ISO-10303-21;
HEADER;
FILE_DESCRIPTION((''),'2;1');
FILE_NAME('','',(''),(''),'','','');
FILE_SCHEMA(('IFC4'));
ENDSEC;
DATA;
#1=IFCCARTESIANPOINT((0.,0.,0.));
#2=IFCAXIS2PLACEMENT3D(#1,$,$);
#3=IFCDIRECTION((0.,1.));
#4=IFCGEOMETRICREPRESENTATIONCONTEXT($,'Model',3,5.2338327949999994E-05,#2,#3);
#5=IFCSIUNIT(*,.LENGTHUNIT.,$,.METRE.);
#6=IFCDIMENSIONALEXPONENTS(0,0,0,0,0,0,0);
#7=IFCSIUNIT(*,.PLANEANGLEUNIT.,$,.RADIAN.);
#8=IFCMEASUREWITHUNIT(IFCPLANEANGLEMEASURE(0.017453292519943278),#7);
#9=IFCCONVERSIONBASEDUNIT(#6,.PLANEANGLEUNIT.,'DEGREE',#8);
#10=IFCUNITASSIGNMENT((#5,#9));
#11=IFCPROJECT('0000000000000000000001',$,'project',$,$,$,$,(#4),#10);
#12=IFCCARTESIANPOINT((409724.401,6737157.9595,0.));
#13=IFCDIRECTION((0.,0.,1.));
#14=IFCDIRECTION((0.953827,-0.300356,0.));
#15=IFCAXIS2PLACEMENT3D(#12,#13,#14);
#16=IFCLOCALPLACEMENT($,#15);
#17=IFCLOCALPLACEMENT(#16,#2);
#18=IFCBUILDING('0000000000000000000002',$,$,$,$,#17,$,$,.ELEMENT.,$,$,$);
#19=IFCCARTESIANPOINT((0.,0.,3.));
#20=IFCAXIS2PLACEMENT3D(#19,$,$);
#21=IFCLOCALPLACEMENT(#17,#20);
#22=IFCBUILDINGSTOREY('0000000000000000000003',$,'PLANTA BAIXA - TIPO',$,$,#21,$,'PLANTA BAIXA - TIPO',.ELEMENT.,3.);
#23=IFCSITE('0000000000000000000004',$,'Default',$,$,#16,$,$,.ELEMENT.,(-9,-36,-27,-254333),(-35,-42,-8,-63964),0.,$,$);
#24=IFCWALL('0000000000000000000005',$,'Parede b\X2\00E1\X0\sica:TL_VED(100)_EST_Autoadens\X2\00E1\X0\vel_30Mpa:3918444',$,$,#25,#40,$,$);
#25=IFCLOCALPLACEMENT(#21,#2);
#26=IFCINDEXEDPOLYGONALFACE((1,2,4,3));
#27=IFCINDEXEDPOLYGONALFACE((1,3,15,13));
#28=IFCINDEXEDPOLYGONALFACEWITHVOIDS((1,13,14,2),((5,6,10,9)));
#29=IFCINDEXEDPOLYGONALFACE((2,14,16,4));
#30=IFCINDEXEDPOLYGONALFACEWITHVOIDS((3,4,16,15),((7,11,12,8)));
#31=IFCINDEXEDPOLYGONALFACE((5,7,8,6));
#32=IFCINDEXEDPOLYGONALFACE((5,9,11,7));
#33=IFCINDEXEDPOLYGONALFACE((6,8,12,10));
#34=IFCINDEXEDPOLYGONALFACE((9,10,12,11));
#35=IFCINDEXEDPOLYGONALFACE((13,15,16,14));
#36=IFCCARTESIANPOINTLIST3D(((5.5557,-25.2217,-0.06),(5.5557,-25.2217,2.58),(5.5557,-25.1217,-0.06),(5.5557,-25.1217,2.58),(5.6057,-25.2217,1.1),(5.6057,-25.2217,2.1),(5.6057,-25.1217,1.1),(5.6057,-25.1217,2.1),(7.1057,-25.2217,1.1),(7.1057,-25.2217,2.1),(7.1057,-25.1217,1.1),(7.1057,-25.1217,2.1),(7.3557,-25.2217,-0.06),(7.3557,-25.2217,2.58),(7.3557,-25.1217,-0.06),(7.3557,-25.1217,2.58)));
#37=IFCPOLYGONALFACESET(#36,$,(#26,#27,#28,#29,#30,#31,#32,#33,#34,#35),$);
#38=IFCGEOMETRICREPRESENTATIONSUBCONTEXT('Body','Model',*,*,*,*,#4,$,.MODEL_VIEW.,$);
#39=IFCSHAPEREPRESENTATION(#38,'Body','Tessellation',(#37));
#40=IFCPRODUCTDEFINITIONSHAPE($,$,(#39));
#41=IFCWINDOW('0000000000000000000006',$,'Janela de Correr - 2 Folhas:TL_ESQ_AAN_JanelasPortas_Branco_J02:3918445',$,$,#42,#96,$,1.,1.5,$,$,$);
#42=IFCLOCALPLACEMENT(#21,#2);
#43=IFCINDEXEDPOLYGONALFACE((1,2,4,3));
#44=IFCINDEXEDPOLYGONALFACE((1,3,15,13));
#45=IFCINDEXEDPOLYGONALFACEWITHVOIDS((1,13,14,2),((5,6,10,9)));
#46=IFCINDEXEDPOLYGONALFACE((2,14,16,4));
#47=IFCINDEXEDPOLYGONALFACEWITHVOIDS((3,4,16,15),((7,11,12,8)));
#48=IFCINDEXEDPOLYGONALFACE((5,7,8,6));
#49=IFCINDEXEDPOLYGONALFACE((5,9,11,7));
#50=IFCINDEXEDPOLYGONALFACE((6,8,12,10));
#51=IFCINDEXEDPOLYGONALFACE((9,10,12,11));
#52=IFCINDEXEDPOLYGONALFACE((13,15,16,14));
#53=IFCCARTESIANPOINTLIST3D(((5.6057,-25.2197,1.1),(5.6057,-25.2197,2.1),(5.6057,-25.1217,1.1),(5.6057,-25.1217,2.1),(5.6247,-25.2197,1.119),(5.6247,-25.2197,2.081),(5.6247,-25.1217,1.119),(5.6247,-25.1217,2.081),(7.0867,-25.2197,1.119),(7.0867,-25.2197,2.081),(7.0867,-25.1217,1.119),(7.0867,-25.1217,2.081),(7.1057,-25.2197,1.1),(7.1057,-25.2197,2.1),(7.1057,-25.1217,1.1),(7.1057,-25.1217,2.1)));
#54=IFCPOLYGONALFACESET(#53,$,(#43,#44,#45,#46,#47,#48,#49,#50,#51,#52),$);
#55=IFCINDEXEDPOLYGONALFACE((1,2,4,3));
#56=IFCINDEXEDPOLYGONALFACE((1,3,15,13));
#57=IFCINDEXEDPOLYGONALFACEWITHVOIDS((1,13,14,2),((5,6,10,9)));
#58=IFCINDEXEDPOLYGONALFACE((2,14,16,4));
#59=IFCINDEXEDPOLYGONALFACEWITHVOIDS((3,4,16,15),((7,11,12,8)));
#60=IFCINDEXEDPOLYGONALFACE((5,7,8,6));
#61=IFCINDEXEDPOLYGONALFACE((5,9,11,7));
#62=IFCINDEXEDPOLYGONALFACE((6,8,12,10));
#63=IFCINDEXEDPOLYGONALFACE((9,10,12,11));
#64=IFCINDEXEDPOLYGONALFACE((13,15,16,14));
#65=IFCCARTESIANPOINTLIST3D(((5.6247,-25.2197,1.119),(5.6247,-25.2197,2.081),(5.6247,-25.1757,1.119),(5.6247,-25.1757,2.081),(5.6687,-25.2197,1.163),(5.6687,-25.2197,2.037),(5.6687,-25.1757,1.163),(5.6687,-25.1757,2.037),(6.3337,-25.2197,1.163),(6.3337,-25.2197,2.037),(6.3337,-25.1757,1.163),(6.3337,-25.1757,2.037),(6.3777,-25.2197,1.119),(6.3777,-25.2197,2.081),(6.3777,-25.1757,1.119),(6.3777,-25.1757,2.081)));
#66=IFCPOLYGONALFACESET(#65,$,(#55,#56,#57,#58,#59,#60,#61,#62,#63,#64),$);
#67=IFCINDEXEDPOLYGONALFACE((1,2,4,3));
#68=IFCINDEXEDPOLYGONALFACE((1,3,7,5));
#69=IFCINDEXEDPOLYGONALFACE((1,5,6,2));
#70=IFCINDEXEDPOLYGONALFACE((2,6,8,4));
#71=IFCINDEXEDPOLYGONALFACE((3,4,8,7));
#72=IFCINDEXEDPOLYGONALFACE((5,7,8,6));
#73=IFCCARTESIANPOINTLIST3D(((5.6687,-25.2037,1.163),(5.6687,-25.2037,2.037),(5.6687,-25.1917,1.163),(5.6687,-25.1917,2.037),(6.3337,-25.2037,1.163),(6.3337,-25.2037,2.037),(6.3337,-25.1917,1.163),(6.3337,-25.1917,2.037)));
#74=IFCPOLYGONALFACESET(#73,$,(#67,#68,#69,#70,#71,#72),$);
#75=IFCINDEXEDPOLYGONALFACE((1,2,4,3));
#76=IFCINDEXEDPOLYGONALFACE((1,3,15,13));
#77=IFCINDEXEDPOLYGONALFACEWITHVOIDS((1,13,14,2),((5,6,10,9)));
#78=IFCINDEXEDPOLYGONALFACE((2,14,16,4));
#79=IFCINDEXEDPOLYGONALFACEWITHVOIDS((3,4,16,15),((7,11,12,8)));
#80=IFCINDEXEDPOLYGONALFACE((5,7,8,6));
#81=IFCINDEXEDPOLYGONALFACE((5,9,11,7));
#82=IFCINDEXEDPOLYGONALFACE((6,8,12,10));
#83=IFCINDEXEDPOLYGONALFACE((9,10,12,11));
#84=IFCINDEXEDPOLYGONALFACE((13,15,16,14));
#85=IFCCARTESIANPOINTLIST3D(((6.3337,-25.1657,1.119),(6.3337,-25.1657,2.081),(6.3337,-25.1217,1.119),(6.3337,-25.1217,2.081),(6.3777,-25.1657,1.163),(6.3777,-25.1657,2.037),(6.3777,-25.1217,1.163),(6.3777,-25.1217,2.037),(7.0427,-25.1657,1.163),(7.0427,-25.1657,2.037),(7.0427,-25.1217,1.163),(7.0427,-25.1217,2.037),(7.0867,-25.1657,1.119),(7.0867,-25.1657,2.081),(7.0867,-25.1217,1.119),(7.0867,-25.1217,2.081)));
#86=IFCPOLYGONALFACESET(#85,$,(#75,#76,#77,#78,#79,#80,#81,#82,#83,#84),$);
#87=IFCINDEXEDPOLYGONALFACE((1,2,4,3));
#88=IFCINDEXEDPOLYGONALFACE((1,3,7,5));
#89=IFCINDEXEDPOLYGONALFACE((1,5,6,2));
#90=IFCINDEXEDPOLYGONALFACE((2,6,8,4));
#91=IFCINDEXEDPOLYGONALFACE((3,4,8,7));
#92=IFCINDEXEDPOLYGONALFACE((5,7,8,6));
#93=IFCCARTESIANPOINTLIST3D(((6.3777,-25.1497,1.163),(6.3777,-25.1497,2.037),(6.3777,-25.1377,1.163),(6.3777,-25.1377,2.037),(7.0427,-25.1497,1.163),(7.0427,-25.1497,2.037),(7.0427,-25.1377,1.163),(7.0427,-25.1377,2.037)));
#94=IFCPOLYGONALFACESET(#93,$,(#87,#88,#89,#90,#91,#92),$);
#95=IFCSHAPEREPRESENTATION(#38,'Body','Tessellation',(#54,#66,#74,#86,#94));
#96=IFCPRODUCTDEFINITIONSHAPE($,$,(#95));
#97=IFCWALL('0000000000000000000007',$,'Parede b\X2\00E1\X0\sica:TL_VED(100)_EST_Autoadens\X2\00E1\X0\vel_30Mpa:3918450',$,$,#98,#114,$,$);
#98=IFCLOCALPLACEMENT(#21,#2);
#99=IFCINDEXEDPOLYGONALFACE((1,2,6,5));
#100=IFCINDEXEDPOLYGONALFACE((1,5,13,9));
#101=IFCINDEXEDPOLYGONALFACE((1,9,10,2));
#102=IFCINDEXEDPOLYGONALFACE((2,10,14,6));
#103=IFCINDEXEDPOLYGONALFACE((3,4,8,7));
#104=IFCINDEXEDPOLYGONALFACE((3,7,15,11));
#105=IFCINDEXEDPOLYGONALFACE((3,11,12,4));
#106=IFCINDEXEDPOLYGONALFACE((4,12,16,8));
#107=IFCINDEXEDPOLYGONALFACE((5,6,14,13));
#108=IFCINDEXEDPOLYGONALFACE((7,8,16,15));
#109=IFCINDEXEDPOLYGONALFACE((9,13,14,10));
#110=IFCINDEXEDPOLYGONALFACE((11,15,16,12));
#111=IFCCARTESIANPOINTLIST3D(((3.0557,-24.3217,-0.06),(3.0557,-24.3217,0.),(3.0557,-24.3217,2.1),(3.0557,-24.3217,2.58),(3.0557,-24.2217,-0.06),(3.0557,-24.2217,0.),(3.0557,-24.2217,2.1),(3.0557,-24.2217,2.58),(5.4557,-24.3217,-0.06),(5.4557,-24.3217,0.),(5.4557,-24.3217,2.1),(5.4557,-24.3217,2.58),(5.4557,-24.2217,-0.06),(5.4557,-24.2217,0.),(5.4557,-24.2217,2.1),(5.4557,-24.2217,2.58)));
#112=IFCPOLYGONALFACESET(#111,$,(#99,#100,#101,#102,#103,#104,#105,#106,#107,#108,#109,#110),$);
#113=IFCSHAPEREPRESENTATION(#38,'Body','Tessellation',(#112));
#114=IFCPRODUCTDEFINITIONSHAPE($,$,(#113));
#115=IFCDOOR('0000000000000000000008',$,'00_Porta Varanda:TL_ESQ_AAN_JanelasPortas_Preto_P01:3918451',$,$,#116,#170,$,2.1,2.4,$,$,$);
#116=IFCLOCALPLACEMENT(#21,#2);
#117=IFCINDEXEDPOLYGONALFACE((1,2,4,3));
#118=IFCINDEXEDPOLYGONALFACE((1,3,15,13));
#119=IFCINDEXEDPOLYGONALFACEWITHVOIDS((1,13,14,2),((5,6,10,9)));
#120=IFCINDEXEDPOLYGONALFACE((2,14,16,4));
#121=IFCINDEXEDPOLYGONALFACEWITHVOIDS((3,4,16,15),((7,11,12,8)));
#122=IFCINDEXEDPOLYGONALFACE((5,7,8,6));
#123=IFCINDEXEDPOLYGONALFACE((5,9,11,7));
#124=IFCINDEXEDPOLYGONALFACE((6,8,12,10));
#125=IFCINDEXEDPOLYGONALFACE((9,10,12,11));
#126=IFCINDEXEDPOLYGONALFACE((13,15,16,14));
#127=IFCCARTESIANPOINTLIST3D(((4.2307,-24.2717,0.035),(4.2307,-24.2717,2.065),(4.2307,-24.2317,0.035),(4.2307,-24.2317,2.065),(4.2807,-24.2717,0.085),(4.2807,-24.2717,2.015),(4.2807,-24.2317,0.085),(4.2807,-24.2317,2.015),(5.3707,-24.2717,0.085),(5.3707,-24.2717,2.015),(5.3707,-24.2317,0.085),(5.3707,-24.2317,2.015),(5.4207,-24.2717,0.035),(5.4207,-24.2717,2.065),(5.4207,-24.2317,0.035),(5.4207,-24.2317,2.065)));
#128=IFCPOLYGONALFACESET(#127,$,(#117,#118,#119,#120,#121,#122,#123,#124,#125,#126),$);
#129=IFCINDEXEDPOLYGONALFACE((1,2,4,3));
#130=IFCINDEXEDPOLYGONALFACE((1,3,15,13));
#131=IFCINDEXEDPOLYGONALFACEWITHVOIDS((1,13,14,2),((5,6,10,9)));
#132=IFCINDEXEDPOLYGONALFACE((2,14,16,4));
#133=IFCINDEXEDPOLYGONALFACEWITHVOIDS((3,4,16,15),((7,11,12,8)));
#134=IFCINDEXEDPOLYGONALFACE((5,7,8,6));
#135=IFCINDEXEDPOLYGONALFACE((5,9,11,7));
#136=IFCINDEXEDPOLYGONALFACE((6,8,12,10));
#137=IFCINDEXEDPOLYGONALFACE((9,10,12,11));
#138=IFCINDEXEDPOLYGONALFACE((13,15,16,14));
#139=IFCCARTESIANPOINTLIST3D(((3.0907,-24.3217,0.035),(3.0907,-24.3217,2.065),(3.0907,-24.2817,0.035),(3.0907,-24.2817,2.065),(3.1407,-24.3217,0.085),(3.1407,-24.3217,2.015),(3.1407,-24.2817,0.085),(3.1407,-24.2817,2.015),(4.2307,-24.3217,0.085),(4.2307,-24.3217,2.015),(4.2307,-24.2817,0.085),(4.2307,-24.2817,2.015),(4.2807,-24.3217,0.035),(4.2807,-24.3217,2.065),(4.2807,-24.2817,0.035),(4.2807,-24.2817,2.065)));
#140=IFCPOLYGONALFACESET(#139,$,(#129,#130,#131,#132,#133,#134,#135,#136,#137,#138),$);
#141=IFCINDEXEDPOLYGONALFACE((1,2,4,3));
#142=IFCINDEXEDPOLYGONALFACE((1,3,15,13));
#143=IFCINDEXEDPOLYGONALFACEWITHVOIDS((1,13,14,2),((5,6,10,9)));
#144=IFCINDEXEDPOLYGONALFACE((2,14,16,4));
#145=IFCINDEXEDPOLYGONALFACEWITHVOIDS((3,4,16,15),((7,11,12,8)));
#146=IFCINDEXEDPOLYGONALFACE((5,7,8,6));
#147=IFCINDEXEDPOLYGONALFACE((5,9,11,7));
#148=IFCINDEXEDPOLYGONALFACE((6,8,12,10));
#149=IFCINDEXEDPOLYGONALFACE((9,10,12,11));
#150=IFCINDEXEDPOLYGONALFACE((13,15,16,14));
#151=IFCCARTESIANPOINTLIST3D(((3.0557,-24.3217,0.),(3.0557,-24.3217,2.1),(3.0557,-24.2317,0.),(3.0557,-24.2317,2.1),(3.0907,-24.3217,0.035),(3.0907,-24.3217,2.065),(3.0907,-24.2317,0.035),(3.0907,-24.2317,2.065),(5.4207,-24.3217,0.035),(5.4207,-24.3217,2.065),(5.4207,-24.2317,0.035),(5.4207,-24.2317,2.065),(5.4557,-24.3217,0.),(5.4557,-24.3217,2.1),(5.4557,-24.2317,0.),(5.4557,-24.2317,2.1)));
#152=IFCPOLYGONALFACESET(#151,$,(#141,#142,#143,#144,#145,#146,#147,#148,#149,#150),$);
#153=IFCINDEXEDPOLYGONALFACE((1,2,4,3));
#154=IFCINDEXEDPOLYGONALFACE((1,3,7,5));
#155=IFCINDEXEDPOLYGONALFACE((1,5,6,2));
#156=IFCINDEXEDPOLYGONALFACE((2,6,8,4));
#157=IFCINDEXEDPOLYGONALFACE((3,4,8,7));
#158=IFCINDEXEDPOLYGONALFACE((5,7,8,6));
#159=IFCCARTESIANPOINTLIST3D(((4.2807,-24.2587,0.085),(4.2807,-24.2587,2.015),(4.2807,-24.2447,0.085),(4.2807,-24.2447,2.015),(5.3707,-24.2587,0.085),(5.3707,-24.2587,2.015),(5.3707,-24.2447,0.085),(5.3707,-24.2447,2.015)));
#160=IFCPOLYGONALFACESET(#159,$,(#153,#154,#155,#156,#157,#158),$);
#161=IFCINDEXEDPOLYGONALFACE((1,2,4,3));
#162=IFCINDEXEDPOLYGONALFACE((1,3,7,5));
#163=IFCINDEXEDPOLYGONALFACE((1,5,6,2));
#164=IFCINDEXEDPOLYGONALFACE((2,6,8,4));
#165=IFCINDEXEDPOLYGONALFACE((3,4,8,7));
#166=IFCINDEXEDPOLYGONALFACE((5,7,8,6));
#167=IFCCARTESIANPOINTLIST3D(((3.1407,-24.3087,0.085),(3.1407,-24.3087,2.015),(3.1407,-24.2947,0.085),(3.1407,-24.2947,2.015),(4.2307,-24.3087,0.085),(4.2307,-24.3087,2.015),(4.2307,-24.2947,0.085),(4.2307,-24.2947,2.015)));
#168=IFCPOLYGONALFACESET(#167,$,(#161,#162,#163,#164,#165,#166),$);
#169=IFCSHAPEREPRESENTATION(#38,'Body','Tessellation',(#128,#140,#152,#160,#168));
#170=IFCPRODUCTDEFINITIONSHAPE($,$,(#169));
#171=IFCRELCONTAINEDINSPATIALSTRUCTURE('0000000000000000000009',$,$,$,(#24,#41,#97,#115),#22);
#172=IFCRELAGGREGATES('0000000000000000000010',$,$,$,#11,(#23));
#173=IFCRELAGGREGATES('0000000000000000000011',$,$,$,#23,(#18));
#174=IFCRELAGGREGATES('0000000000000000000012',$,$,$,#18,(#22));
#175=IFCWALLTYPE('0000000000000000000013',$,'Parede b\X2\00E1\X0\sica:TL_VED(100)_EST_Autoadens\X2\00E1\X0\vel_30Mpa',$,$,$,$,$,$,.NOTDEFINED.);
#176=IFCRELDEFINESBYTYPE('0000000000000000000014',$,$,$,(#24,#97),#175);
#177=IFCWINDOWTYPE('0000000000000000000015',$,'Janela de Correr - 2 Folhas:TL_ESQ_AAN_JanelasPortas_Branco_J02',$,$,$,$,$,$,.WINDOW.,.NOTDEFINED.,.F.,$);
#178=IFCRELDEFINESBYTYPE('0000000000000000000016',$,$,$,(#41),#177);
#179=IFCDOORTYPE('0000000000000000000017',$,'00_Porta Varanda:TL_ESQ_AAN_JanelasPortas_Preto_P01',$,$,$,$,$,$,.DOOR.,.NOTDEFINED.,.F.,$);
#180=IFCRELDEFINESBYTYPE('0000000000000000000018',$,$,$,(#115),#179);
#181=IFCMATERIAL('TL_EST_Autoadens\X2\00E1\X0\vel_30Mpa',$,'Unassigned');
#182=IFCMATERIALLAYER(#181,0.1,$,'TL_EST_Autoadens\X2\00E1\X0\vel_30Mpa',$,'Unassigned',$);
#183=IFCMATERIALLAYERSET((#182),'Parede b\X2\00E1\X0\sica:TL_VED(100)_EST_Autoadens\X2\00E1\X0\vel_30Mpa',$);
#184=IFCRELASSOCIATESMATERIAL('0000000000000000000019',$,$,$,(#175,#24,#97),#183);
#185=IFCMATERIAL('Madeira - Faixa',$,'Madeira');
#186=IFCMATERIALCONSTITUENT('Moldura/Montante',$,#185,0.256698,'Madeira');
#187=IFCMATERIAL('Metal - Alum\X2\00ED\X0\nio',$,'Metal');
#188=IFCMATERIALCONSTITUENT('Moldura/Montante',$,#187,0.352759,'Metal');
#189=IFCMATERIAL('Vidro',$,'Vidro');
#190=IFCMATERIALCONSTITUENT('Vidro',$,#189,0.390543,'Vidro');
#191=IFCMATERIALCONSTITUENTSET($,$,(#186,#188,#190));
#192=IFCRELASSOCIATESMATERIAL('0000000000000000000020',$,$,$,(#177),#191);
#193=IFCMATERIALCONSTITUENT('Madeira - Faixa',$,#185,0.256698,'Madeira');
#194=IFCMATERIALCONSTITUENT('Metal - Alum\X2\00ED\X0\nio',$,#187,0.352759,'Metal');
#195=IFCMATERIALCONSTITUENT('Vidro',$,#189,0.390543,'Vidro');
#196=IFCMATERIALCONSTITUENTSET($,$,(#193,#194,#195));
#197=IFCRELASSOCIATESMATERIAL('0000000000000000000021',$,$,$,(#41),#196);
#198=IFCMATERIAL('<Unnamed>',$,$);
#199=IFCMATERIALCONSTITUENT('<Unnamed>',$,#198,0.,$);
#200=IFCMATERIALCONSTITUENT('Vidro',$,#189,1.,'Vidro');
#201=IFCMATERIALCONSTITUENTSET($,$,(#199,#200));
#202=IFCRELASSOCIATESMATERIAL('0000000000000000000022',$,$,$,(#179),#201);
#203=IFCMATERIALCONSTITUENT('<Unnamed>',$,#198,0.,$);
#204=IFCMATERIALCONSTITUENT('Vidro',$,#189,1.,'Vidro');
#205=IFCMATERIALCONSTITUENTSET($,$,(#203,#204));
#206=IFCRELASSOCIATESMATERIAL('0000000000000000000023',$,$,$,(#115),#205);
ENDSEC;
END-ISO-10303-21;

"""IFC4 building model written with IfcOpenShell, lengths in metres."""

from ifc_helpers import new_model, entity, si_unit, converted_unit, direction, frame, frame_2d, origin, origin_2d_with_axis, place, context, subcontext, project, spatial, polyline, rectangle, outline, extrude, source, transform, mapped, material, layer, layer_set, layer_usage, constituent, constituent_set, type_object, type_shapes, element, fill, save


model = new_model("IFC4")

# Units and contexts
model_context = context("Model", 3, precision=5.2338327949999994e-05, world=origin(), true_north=direction((0.0, 1.0)))
body_context = subcontext(model_context, "Body", "Model", "MODEL_VIEW")
ifc_project = project(units=[si_unit("LENGTHUNIT", "METRE"), converted_unit("PLANEANGLEUNIT", "DEGREE", entity("IfcPlaneAngleMeasure", 0.017453292519943278), si_unit("PLANEANGLEUNIT", "RADIAN"), dimensions=[0, 0, 0, 0, 0, 0, 0])], contexts=[model_context])

# Site, building, storey
site_placement = place(None, frame((409724.401, 6737157.9595, 0.0), z_axis=(0.0, 0.0, 1.0), x_axis=(0.953827, -0.300356, 0.0)))
site = spatial("IfcSite", under=ifc_project, at=site_placement, Name="Default", CompositionType="ELEMENT", RefLatitude=(-9, -36, -27, -254333), RefLongitude=(-35, -42, -8, -63964), RefElevation=0.0)
building_placement = place(site_placement, origin())
building = spatial("IfcBuilding", under=site, at=building_placement, CompositionType="ELEMENT")
storey_placement = place(building_placement, frame((0.0, 0.0, 3.0)))
storey = spatial("IfcBuildingStorey", under=building, at=storey_placement, Name="PLANTA BAIXA - TIPO", LongName="PLANTA BAIXA - TIPO", CompositionType="ELEMENT", Elevation=3.0)

# Shared definitions
ifc_material_1 = material(Name="TL_EST_Autoadensável_30Mpa", Category="Unassigned")
ifc_layer_1 = layer(ifc_material_1, 0.1, Name="TL_EST_Autoadensável_30Mpa", Category="Unassigned")
ifc_layer_set_1 = layer_set([ifc_layer_1], Name="Parede básica:TL_VED(100)_EST_Autoadensável_30Mpa")
wall_type_1 = type_object("IfcWallType", Name="Parede básica:TL_VED(100)_EST_Autoadensável_30Mpa", PredefinedType="NOTDEFINED", material=ifc_layer_set_1)

# Wall, opening, window
ifc_layer_usage_1 = layer_usage(ifc_layer_set_1, "AXIS2", "POSITIVE", -0.05)
wall_1_placement = place(storey_placement, frame((5.5557, -25.1717, -0.06)))
wall_1 = element("IfcWall", 1, at=wall_1_placement, inside=storey, type_object=wall_type_1, material=ifc_layer_usage_1, Name="Parede básica:TL_VED(100)_EST_Autoadensável_30Mpa:3918444", context=body_context, shape_type="SweptSolid", body=[
    extrude(rectangle(XDim=1.8, YDim=0.1, at=frame_2d((0.9, 0.0), x_axis=(-1.0, 0.0))), origin(), (0.0, 0.0, 1.0), 2.64),
])
opening_1_placement = place(wall_1_placement, frame((1.55, 0.05, 1.16)))
opening_1 = element("IfcOpeningElement", 2, at=opening_1_placement, cuts=wall_1, PredefinedType="OPENING", context=body_context, shape_type="SweptSolid", body=[
    extrude(rectangle(XDim=1.0, YDim=1.5, at=frame_2d((0.5, 0.75), x_axis=(-1.0, 0.0))), frame((0.0, 0.0, 0.0), z_axis=(0.0, -1.0, 0.0), x_axis=(0.0, 0.0, 1.0)), (0.0, 0.0, 1.0), 0.1),
])
ifc_material_2 = material(Name="Madeira - Faixa", Category="Madeira")
ifc_constituent_1 = constituent(ifc_material_2, Name="Madeira - Faixa", Category="Madeira", fraction=0.256698)
ifc_material_3 = material(Name="Metal - Alumínio", Category="Metal")
ifc_constituent_2 = constituent(ifc_material_3, Name="Metal - Alumínio", Category="Metal", fraction=0.352759)
ifc_material_4 = material(Name="Vidro", Category="Vidro")
ifc_constituent_3 = constituent(ifc_material_4, Name="Vidro", Category="Vidro", fraction=0.390543)
ifc_constituent_set_1 = constituent_set(constituents=[ifc_constituent_1, ifc_constituent_2, ifc_constituent_3])
ifc_constituent_4 = constituent(ifc_material_2, Name="Moldura/Montante", Category="Madeira", fraction=0.256698)
ifc_constituent_5 = constituent(ifc_material_3, Name="Moldura/Montante", Category="Metal", fraction=0.352759)
ifc_constituent_6 = constituent(ifc_material_4, Name="Vidro", Category="Vidro", fraction=0.390543)
ifc_constituent_set_2 = constituent_set(constituents=[ifc_constituent_4, ifc_constituent_5, ifc_constituent_6])
window_type = type_object("IfcWindowType", Name="Janela de Correr - 2 Folhas:TL_ESQ_AAN_JanelasPortas_Branco_J02", ParameterTakesPrecedence=False, PartitioningType="NOTDEFINED", PredefinedType="WINDOW", material=ifc_constituent_set_2)
shared_shape_1 = source(origin(), body_context, "Body", "SweptSolid", [
    extrude(outline(polyline([(-0.75, -0.5), (0.75, -0.5), (0.75, 0.5), (-0.75, 0.5), (-0.75, -0.5)]), holes=[polyline([(-0.731, -0.481), (-0.731, 0.481), (0.731, 0.481), (0.731, -0.481), (-0.731, -0.481)])]), frame((0.75, 0.0, 0.5), z_axis=(0.0, 1.0, 0.0), x_axis=(1.0, 0.0, 0.0)), (0.0, 0.0, 1.0), 0.098),
    extrude(outline(polyline([(-0.3765, -0.481), (0.3765, -0.481), (0.3765, 0.481), (-0.3765, 0.481), (-0.3765, -0.481)]), holes=[polyline([(-0.3325, -0.437), (-0.3325, 0.437), (0.3325, 0.437), (0.3325, -0.437), (-0.3325, -0.437)])]), frame((1.1045, 0.054, 0.5), z_axis=(0.0, 1.0, 0.0), x_axis=(1.0, 0.0, 0.0)), (0.0, 0.0, 1.0), 0.044),
    extrude(rectangle(XDim=0.012, YDim=0.665, at=origin_2d_with_axis()), frame((1.1045, 0.076, 0.063), z_axis=(0.0, 0.0, 1.0), x_axis=(0.0, -1.0, 0.0)), (0.0, 0.0, 1.0), 0.874),
    extrude(outline(polyline([(-0.481, -0.3765), (0.481, -0.3765), (0.481, 0.3765), (-0.481, 0.3765), (-0.481, -0.3765)]), holes=[polyline([(-0.437, -0.3325), (-0.437, 0.3325), (0.437, 0.3325), (0.437, -0.3325), (-0.437, -0.3325)])]), frame((0.3955, 0.0, 0.5), z_axis=(0.0, 1.0, 0.0), x_axis=(0.0, 0.0, -1.0)), (0.0, 0.0, 1.0), 0.044),
    extrude(rectangle(XDim=0.012, YDim=0.665, at=origin_2d_with_axis()), frame((0.3955, 0.022, 0.063), z_axis=(0.0, 0.0, 1.0), x_axis=(0.0, -1.0, 0.0)), (0.0, 0.0, 1.0), 0.874),
])
type_shapes(window_type, [shared_shape_1])
window_placement = place(opening_1_placement, frame((0.0, 0.0, 0.0), z_axis=(0.0, 0.0, 1.0), x_axis=(-1.0, 0.0, 0.0)))
window = element("IfcWindow", 3, at=window_placement, inside=storey, type_object=window_type, material=ifc_constituent_set_1, Name="Janela de Correr - 2 Folhas:TL_ESQ_AAN_JanelasPortas_Branco_J02:3918445", OverallHeight=1.0, OverallWidth=1.5, context=body_context, shape_type="MappedRepresentation", body=[
    mapped(shared_shape_1, transform((0.0, 0.0, 0.0), scale=1.0)),
])
fill(opening_1, window)

# Wall, opening, door
ifc_layer_usage_2 = layer_usage(ifc_layer_set_1, "AXIS2", "POSITIVE", -0.05)
wall_2_placement = place(storey_placement, frame((3.0557, -24.2717, -0.06)))
wall_2 = element("IfcWall", 4, at=wall_2_placement, inside=storey, type_object=wall_type_1, material=ifc_layer_usage_2, Name="Parede básica:TL_VED(100)_EST_Autoadensável_30Mpa:3918450", context=body_context, shape_type="SweptSolid", body=[
    extrude(rectangle(XDim=2.4, YDim=0.1, at=frame_2d((1.2, 0.0), x_axis=(-1.0, 0.0))), origin(), (0.0, 0.0, 1.0), 2.64),
])
opening_2_placement = place(wall_2_placement, frame((0.0, -0.05, 0.06)))
opening_2 = element("IfcOpeningElement", 5, at=opening_2_placement, cuts=wall_2, PredefinedType="OPENING", context=body_context, shape_type="SweptSolid", body=[
    extrude(rectangle(XDim=2.1, YDim=2.4, at=frame_2d((1.05, 1.2), x_axis=(1.0, 0.0))), frame((0.0, 0.0, 0.0), z_axis=(0.0, 1.0, 0.0), x_axis=(0.0, 0.0, 1.0)), (0.0, 0.0, 1.0), 0.1),
])
ifc_material_5 = material(Name="<Unnamed>")
ifc_constituent_7 = constituent(ifc_material_5, Name="<Unnamed>", fraction=0.0)
ifc_constituent_8 = constituent(ifc_material_4, Name="Vidro", Category="Vidro", fraction=1.0)
ifc_constituent_set_3 = constituent_set(constituents=[ifc_constituent_7, ifc_constituent_8])
ifc_constituent_9 = constituent(ifc_material_5, Name="<Unnamed>", fraction=0.0)
ifc_constituent_10 = constituent(ifc_material_4, Name="Vidro", Category="Vidro", fraction=1.0)
ifc_constituent_set_4 = constituent_set(constituents=[ifc_constituent_9, ifc_constituent_10])
door_type = type_object("IfcDoorType", Name="00_Porta Varanda:TL_ESQ_AAN_JanelasPortas_Preto_P01", OperationType="NOTDEFINED", ParameterTakesPrecedence=False, PredefinedType="DOOR", material=ifc_constituent_set_4)
shared_shape_2 = source(origin(), body_context, "Body", "SweptSolid", [
    extrude(outline(polyline([(-1.015, -0.595), (1.015, -0.595), (1.015, 0.595), (-1.015, 0.595), (-1.015, -0.595)]), holes=[polyline([(0.965, -0.545), (-0.965, -0.545), (-0.965, 0.545), (0.965, 0.545), (0.965, -0.545)])]), frame((1.77, 0.05, 1.05), z_axis=(0.0, 1.0, 0.0), x_axis=(0.0, 0.0, 1.0)), (0.0, 0.0, 1.0), 0.04),
    extrude(outline(polyline([(-1.015, -0.595), (1.015, -0.595), (1.015, 0.595), (-1.015, 0.595), (-1.015, -0.595)]), holes=[polyline([(0.965, -0.545), (-0.965, -0.545), (-0.965, 0.545), (0.965, 0.545), (0.965, -0.545)])]), frame((0.63, 0.0, 1.05), z_axis=(0.0, 1.0, 0.0), x_axis=(0.0, 0.0, -1.0)), (0.0, 0.0, 1.0), 0.04),
    extrude(outline(polyline([(-1.05, -1.2), (1.05, -1.2), (1.05, 1.2), (-1.05, 1.2), (-1.05, -1.2)]), holes=[polyline([(1.015, -1.165), (-1.015, -1.165), (-1.015, 1.165), (1.015, 1.165), (1.015, -1.165)])]), frame((1.2, 0.0, 1.05), z_axis=(0.0, 1.0, 0.0), x_axis=(0.0, 0.0, -1.0)), (0.0, 0.0, 1.0), 0.09),
    extrude(rectangle(XDim=0.014, YDim=1.09, at=frame_2d((0.0, 0.0), x_axis=(1.0, 0.0))), frame((1.77, 0.07, 0.085), z_axis=(0.0, 0.0, 1.0), x_axis=(0.0, -1.0, 0.0)), (0.0, 0.0, 1.0), 1.93),
    extrude(rectangle(XDim=0.014, YDim=1.09, at=frame_2d((0.0, 0.0), x_axis=(1.0, 0.0))), frame((0.63, 0.02, 0.085), z_axis=(0.0, 0.0, 1.0), x_axis=(0.0, -1.0, 0.0)), (0.0, 0.0, 1.0), 1.93),
])
type_shapes(door_type, [shared_shape_2])
door_placement = place(opening_2_placement, origin())
door = element("IfcDoor", 6, at=door_placement, inside=storey, type_object=door_type, material=ifc_constituent_set_3, Name="00_Porta Varanda:TL_ESQ_AAN_JanelasPortas_Preto_P01:3918451", OverallHeight=2.1, OverallWidth=2.4, context=body_context, shape_type="MappedRepresentation", body=[
    mapped(shared_shape_2, transform((0.0, 0.0, 0.0), scale=1.0)),
])
fill(opening_2, door)

save(model, "model.ifc")
